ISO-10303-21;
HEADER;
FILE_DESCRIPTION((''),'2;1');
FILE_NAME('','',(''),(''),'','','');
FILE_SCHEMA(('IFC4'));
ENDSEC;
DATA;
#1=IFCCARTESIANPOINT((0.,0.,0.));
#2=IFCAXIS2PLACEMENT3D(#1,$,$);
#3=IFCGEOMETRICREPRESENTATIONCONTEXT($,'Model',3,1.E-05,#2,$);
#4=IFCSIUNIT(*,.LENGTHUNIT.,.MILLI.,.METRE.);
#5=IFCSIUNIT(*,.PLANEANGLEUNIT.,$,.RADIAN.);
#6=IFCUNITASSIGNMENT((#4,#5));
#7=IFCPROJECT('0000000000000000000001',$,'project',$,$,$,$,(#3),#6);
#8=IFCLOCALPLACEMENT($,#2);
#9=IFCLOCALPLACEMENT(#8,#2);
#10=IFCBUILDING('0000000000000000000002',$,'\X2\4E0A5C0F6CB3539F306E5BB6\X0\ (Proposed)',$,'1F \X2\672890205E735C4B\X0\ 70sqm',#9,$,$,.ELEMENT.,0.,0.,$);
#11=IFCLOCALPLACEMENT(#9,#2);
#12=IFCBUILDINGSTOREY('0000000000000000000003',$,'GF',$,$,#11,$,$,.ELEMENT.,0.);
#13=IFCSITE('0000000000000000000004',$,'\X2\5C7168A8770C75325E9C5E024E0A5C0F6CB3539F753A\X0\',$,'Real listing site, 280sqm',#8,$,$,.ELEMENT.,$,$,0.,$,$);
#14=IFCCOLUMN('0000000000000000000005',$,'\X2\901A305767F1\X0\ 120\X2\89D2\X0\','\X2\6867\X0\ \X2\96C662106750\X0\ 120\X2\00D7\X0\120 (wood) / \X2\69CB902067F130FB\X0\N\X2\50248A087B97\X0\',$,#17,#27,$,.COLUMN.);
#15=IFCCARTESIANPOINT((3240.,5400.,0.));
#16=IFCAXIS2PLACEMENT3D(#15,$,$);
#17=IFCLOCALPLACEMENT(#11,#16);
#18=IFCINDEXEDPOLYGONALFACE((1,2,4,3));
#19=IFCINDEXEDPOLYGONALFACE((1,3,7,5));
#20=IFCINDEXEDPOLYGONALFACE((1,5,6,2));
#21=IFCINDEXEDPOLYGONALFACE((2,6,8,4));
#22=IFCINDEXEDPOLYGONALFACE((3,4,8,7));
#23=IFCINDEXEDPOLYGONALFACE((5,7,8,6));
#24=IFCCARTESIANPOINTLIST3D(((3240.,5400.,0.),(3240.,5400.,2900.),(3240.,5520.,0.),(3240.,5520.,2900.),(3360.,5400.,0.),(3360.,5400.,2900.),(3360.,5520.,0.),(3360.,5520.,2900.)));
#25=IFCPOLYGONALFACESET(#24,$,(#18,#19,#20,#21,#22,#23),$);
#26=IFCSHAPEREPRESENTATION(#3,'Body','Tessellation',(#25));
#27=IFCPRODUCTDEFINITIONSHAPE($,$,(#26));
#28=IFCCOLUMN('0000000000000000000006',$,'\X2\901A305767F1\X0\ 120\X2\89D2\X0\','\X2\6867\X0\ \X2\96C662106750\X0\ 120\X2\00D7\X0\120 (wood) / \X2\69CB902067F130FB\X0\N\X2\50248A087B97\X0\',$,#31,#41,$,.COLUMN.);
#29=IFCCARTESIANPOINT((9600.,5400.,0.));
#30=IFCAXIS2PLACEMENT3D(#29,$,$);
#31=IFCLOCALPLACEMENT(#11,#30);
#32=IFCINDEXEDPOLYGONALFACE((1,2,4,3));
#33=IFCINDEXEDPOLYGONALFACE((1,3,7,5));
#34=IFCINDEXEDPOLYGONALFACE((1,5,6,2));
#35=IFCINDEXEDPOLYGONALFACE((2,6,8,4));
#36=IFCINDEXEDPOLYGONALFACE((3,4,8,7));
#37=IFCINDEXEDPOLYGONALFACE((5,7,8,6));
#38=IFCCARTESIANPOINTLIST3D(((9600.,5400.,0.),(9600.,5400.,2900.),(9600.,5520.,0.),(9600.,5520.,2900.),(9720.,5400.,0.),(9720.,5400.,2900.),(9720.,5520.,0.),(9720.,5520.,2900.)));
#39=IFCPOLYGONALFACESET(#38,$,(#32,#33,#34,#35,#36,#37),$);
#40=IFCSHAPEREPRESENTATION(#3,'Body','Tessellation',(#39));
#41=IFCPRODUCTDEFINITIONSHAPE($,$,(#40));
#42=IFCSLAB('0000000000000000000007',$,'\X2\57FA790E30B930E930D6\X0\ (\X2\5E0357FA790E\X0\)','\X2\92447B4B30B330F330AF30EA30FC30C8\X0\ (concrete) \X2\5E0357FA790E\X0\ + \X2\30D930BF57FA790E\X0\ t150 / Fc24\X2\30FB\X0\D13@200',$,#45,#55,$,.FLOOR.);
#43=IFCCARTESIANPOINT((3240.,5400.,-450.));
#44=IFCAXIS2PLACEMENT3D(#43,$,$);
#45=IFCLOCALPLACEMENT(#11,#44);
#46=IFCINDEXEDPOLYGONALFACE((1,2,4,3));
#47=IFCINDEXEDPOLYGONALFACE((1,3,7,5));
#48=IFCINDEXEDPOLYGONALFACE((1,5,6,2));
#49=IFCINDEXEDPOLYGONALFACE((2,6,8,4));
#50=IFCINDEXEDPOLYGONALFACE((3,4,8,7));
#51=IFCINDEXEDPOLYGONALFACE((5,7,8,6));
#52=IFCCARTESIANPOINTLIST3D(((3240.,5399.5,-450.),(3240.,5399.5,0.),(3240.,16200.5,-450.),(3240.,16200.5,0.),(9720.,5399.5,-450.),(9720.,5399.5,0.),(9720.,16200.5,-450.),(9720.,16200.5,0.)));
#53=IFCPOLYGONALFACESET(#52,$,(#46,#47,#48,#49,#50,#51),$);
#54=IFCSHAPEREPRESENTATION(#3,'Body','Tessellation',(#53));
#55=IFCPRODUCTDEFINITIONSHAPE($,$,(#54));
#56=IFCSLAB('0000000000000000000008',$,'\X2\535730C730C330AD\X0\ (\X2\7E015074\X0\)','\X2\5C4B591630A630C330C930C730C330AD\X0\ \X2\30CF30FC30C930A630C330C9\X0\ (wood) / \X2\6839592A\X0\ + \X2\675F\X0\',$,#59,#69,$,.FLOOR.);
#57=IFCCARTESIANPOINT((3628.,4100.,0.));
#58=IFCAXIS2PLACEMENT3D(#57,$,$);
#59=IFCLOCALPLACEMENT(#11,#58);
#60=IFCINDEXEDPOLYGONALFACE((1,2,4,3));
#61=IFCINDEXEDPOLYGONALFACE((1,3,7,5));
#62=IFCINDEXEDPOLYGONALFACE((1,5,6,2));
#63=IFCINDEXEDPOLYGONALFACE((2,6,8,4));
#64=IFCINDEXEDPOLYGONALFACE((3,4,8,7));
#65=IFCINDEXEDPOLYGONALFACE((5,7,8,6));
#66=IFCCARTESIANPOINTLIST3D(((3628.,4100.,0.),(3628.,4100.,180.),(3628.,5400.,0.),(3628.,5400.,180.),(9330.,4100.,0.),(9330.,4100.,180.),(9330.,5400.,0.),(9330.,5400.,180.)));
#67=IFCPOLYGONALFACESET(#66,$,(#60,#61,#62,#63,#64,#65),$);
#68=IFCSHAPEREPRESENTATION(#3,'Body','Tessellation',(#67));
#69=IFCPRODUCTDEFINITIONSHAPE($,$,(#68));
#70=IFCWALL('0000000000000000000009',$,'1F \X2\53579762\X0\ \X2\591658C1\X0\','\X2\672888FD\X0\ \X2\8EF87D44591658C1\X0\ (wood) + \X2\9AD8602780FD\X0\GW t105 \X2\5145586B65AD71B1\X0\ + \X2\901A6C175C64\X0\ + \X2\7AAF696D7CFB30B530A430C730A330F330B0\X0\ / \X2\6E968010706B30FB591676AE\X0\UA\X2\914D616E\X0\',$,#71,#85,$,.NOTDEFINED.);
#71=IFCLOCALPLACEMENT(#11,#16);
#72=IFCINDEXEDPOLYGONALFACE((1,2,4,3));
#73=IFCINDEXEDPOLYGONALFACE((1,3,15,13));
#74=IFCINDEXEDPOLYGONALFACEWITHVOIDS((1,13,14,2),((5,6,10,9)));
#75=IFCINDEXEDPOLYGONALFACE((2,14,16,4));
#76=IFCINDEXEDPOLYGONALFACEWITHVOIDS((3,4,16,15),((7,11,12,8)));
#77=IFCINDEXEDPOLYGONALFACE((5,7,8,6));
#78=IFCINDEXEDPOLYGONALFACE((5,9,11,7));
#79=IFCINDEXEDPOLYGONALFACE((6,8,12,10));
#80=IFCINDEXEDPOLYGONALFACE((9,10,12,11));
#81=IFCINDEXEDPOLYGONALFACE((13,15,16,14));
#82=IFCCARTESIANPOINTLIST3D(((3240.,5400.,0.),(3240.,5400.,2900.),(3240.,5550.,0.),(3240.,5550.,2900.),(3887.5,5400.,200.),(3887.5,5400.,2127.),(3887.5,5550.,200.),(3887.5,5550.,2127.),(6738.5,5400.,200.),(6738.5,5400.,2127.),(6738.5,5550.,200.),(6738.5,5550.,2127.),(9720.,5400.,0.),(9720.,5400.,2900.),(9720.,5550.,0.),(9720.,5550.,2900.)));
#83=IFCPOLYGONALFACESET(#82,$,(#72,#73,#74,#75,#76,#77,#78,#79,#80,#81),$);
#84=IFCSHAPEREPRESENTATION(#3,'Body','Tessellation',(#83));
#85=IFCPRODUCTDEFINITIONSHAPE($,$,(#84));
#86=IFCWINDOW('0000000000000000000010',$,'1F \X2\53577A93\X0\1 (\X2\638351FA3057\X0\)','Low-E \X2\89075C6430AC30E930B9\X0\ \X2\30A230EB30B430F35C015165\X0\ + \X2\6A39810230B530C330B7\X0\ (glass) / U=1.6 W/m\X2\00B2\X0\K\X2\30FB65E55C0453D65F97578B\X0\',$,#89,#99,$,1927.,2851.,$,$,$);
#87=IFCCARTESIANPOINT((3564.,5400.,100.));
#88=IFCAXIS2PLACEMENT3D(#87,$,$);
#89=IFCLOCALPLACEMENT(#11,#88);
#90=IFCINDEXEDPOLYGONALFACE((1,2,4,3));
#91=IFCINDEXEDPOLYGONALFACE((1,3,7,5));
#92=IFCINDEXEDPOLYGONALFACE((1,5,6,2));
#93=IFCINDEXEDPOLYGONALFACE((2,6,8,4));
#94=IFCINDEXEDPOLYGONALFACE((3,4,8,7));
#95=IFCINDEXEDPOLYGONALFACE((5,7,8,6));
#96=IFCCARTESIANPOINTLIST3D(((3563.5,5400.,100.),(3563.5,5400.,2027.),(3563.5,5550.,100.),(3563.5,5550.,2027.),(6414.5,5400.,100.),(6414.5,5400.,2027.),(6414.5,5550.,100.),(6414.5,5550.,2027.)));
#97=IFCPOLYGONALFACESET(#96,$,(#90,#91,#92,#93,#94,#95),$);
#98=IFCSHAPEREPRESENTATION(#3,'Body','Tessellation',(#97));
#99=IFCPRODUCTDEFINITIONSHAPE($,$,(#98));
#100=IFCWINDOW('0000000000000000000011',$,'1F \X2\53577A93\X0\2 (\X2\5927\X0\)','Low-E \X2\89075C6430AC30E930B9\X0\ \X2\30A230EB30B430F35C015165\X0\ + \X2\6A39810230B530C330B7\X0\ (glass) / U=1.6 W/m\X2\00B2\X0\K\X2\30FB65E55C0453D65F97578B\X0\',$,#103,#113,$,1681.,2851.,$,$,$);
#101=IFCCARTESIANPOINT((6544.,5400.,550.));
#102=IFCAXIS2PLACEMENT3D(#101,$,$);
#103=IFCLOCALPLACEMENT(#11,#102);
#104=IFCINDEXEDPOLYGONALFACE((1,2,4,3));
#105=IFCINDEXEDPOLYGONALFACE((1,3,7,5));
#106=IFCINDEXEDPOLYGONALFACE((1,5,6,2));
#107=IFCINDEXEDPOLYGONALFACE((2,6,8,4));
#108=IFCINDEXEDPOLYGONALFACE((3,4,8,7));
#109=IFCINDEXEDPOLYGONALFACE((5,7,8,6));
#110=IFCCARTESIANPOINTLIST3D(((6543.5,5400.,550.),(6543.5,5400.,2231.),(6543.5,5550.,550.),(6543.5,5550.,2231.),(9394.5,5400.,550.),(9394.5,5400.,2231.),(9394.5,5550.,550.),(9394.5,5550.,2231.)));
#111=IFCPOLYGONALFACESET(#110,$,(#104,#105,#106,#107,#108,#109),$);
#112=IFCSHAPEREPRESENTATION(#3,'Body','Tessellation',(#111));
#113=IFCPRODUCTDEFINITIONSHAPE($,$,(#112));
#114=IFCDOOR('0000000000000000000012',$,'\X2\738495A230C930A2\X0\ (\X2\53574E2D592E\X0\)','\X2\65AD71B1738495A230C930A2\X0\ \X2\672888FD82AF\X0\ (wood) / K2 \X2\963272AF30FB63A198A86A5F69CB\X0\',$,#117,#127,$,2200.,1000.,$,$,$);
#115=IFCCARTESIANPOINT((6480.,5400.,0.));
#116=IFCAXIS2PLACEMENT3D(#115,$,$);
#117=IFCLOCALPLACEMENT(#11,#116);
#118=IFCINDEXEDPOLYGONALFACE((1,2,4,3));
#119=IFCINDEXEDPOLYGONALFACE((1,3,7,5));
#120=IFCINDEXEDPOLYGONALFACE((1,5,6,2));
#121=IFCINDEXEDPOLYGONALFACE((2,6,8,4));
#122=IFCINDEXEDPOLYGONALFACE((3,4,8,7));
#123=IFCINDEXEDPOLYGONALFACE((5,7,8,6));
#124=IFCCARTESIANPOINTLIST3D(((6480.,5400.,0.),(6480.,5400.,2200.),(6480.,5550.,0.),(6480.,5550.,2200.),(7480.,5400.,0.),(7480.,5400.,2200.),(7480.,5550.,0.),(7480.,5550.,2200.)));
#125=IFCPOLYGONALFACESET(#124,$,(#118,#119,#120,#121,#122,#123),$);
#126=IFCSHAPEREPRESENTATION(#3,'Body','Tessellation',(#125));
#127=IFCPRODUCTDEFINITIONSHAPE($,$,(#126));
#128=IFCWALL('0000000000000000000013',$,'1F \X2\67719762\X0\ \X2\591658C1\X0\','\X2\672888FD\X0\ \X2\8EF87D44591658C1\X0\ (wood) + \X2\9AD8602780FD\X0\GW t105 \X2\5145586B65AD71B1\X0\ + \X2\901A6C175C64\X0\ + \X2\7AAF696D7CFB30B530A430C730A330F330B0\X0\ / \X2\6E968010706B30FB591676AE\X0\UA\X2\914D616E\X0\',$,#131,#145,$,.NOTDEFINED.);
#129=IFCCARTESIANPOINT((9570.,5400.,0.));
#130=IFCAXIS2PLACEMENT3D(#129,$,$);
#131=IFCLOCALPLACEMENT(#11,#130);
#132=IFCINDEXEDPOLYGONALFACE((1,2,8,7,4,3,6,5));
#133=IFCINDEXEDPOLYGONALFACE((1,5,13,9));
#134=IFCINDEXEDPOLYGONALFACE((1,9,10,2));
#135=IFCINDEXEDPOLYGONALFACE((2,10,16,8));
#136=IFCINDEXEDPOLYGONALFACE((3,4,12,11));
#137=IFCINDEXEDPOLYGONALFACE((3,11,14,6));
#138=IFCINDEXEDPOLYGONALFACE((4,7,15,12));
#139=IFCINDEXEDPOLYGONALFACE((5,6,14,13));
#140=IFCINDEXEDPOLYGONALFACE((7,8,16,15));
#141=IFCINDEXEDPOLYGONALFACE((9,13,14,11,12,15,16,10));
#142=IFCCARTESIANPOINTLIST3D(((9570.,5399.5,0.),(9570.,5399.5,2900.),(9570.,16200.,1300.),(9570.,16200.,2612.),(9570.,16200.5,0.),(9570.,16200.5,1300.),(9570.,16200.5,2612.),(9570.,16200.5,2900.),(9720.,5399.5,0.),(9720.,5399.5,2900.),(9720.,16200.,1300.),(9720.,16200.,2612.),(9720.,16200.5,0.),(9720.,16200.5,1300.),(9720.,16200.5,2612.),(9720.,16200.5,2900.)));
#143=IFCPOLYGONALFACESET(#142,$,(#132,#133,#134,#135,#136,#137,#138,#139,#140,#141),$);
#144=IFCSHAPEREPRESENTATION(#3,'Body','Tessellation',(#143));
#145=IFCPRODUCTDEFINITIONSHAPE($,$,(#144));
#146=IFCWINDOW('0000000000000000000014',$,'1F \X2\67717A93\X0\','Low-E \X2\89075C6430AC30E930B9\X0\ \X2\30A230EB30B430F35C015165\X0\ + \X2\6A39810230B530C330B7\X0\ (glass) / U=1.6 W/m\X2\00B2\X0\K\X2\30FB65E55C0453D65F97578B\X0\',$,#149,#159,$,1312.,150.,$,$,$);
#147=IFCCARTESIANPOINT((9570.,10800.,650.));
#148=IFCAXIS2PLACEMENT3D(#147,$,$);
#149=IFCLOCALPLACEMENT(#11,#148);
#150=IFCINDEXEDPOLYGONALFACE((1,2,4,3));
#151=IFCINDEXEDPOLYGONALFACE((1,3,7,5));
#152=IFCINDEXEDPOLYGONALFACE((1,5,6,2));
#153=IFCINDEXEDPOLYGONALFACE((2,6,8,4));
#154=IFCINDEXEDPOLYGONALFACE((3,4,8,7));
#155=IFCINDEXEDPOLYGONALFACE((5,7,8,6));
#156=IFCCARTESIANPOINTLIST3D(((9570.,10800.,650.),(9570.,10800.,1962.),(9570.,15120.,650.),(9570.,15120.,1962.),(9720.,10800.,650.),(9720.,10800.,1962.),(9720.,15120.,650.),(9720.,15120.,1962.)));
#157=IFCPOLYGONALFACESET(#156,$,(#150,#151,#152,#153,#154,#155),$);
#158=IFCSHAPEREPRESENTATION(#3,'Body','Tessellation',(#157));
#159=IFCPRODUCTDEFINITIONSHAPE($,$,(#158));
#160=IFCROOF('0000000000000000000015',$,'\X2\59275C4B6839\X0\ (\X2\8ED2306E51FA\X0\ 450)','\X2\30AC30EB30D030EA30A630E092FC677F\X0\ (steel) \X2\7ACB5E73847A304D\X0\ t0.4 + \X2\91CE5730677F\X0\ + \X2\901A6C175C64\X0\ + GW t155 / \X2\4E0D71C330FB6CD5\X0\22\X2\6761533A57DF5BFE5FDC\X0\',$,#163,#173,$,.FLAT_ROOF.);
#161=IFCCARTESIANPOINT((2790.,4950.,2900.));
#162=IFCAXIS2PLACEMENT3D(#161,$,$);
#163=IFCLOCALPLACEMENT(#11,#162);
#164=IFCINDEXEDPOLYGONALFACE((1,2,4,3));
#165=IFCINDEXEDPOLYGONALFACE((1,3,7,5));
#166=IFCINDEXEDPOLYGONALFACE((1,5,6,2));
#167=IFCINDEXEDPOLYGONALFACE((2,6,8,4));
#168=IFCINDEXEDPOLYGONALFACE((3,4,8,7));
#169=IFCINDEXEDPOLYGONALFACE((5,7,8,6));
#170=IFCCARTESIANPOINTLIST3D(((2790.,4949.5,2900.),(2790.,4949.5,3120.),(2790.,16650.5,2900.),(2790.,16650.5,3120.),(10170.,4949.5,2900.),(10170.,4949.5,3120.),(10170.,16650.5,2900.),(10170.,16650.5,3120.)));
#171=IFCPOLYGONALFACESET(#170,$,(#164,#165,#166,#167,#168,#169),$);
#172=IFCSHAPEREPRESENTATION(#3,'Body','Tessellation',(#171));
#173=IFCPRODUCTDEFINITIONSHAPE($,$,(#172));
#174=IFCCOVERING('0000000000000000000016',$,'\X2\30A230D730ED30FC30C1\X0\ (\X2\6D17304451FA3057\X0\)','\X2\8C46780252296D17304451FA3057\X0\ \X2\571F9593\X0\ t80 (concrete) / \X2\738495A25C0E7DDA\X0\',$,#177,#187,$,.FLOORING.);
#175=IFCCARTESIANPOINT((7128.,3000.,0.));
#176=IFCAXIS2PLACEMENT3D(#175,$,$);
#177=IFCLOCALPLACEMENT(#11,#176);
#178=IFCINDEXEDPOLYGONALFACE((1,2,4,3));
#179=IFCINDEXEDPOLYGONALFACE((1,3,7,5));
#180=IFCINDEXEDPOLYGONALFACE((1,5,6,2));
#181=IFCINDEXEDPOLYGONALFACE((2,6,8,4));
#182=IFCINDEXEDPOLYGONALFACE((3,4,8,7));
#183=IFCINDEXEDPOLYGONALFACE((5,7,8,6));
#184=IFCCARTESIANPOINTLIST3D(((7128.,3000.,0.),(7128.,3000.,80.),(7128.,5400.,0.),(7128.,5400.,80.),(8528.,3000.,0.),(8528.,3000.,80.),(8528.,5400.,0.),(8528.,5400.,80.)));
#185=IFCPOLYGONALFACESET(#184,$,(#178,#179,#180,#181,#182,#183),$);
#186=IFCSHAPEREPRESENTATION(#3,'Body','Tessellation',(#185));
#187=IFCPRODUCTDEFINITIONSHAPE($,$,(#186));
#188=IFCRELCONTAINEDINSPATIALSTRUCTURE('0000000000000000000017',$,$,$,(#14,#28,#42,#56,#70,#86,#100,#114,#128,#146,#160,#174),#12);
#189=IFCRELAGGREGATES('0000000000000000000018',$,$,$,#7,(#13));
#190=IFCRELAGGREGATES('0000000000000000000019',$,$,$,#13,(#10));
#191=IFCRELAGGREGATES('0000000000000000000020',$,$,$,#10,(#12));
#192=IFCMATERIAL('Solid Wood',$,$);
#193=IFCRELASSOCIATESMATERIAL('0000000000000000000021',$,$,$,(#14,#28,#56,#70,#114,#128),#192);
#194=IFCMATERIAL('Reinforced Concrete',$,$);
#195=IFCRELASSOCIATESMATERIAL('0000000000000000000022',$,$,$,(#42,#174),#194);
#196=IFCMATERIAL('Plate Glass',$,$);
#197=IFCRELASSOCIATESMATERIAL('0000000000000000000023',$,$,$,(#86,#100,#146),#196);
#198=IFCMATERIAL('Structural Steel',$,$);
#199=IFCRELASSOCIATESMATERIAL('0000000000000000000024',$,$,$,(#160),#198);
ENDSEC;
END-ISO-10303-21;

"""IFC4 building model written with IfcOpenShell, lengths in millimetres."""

from ifc_helpers import new_model, si_unit, frame, frame_2d, origin, place, context, project, spatial, rectangle, extrude, material, element, fill, save


model = new_model("IFC4")

# Units and contexts
model_context = context("Model", 3, precision=1e-05, world=origin())
ifc_project = project(units=[si_unit("LENGTHUNIT", "METRE", prefix="MILLI"), si_unit("PLANEANGLEUNIT", "RADIAN")], contexts=[model_context])

# Site, building, storey
site_placement = place(None, origin())
site = spatial("IfcSite", under=ifc_project, at=site_placement, Name="山梨県甲府市上小河原町", ObjectType="Real listing site, 280sqm", CompositionType="ELEMENT", RefElevation=0.0)
building_placement = place(site_placement, origin())
building = spatial("IfcBuilding", under=site, at=building_placement, Name="上小河原の家 (Proposed)", ObjectType="1F 木造平屋 70sqm", CompositionType="ELEMENT", ElevationOfRefHeight=0.0, ElevationOfTerrain=0.0)
storey_placement = place(building_placement, origin())
storey = spatial("IfcBuildingStorey", under=building, at=storey_placement, Name="GF", CompositionType="ELEMENT", Elevation=0.0)

# Columns
ifc_material_1 = material(Name="Solid Wood")
column_1_placement = place(storey_placement, frame((3240.0, 5400.0, 0.0)))
element("IfcColumn", 1, at=column_1_placement, inside=storey, material=ifc_material_1, Name="通し柱 120角", Description="桧 集成材 120×120 (wood) / 構造柱・N値計算", PredefinedType="COLUMN", context=model_context, shape_type="SweptSolid", body=[
    extrude(rectangle(XDim=120.0, YDim=120.0, at=frame_2d((60.0, 60.0))), frame((3240.0, 5400.0, 0.0)), (0.0, 0.0, 1.0), 2900.0),
])
column_2_placement = place(storey_placement, frame((9600.0, 5400.0, 0.0)))
element("IfcColumn", 2, at=column_2_placement, inside=storey, material=ifc_material_1, Name="通し柱 120角", Description="桧 集成材 120×120 (wood) / 構造柱・N値計算", PredefinedType="COLUMN", context=model_context, shape_type="SweptSolid", body=[
    extrude(rectangle(XDim=120.0, YDim=120.0, at=frame_2d((60.0, 60.0))), frame((9600.0, 5400.0, 0.0)), (0.0, 0.0, 1.0), 2900.0),
])

# Slabs
ifc_material_2 = material(Name="Reinforced Concrete")
slab_1_placement = place(storey_placement, frame((3240.0, 5400.0, -450.0)))
element("IfcSlab", 3, at=slab_1_placement, inside=storey, material=ifc_material_2, Name="基礎スラブ (布基礎)", Description="鉄筋コンクリート (concrete) 布基礎 + ベタ基礎 t150 / Fc24・D13@200", PredefinedType="FLOOR", context=model_context, shape_type="SweptSolid", body=[
    extrude(rectangle(XDim=6480.0, YDim=10801.0, at=frame_2d((3240.0, 5400.0))), frame((3240.0, 5400.0, -450.0)), (0.0, 0.0, 1.0), 450.0),
])
slab_2_placement = place(storey_placement, frame((3628.0, 4100.0, 0.0)))
element("IfcSlab", 4, at=slab_2_placement, inside=storey, material=ifc_material_1, Name="南デッキ (縁側)", Description="屋外ウッドデッキ ハードウッド (wood) / 根太 + 束", PredefinedType="FLOOR", context=model_context, shape_type="SweptSolid", body=[
    extrude(rectangle(XDim=5702.0, YDim=1300.0, at=frame_2d((2851.0, 650.0))), frame((3628.0, 4100.0, 0.0)), (0.0, 0.0, 1.0), 180.0),
])

# Wall, openings, windows, door
wall_1_placement = place(storey_placement, frame((3240.0, 5400.0, 0.0)))
wall_1 = element("IfcWall", 5, at=wall_1_placement, inside=storey, material=ifc_material_1, Name="1F 南面 外壁", Description="木製 軸組外壁 (wood) + 高性能GW t105 充填断熱 + 通気層 + 窯業系サイディング / 準耐火・外皮UA配慮", PredefinedType="NOTDEFINED", context=model_context, shape_type="SweptSolid", body=[
    extrude(rectangle(XDim=6480.0, YDim=150.0, at=frame_2d((3240.0, 75.0))), frame((3240.0, 5400.0, 0.0)), (0.0, 0.0, 1.0), 2900.0),
])
opening_1_placement = place(storey_placement, frame((3564.0, 5400.0, 100.0)))
opening_1 = element("IfcOpeningElement", 6, at=opening_1_placement, cuts=wall_1, PredefinedType="NOTDEFINED", context=model_context, shape_type="SweptSolid", body=[
    extrude(rectangle(XDim=2851.0, YDim=150.0, at=frame_2d((1425.0, 75.0))), frame((3564.0, 5400.0, 100.0)), (0.0, 0.0, 1.0), 1927.0),
])
opening_2_placement = place(storey_placement, frame((6544.0, 5400.0, 550.0)))
opening_2 = element("IfcOpeningElement", 7, at=opening_2_placement, cuts=wall_1, PredefinedType="NOTDEFINED", context=model_context, shape_type="SweptSolid", body=[
    extrude(rectangle(XDim=2851.0, YDim=150.0, at=frame_2d((1425.0, 75.0))), frame((6544.0, 5400.0, 550.0)), (0.0, 0.0, 1.0), 1681.0),
])
opening_3_placement = place(storey_placement, frame((6480.0, 5400.0, 0.0)))
opening_3 = element("IfcOpeningElement", 8, at=opening_3_placement, cuts=wall_1, PredefinedType="NOTDEFINED", context=model_context, shape_type="SweptSolid", body=[
    extrude(rectangle(XDim=1000.0, YDim=150.0, at=frame_2d((500.0, 75.0))), frame((6480.0, 5400.0, 0.0)), (0.0, 0.0, 1.0), 2200.0),
])
ifc_material_3 = material(Name="Plate Glass")
window_1_placement = place(storey_placement, frame((3564.0, 5400.0, 100.0)))
window_1 = element("IfcWindow", 9, at=window_1_placement, inside=storey, material=ifc_material_3, Name="1F 南窓1 (掃出し)", Description="Low-E 複層ガラス アルゴン封入 + 樹脂サッシ (glass) / U=1.6 W/m²K・日射取得型", OverallHeight=1927.0, OverallWidth=2851.0, context=model_context, shape_type="SweptSolid", body=[
    extrude(rectangle(XDim=2851.0, YDim=150.0, at=frame_2d((1425.0, 75.0))), frame((3564.0, 5400.0, 100.0)), (0.0, 0.0, 1.0), 1927.0),
])
fill(opening_1, window_1)
window_2_placement = place(storey_placement, frame((6544.0, 5400.0, 550.0)))
window_2 = element("IfcWindow", 10, at=window_2_placement, inside=storey, material=ifc_material_3, Name="1F 南窓2 (大)", Description="Low-E 複層ガラス アルゴン封入 + 樹脂サッシ (glass) / U=1.6 W/m²K・日射取得型", OverallHeight=1681.0, OverallWidth=2851.0, context=model_context, shape_type="SweptSolid", body=[
    extrude(rectangle(XDim=2851.0, YDim=150.0, at=frame_2d((1425.0, 75.0))), frame((6544.0, 5400.0, 550.0)), (0.0, 0.0, 1.0), 1681.0),
])
fill(opening_2, window_2)
door_placement = place(storey_placement, frame((6480.0, 5400.0, 0.0)))
door = element("IfcDoor", 11, at=door_placement, inside=storey, material=ifc_material_1, Name="玄関ドア (南中央)", Description="断熱玄関ドア 木製芯 (wood) / K2 防犯・採風機構", OverallHeight=2200.0, OverallWidth=1000.0, context=model_context, shape_type="SweptSolid", body=[
    extrude(rectangle(XDim=1000.0, YDim=150.0, at=frame_2d((500.0, 75.0))), frame((6480.0, 5400.0, 0.0)), (0.0, 0.0, 1.0), 2200.0),
])
fill(opening_3, door)

# Wall, opening, window
wall_2_placement = place(storey_placement, frame((9570.0, 5400.0, 0.0)))
wall_2 = element("IfcWall", 12, at=wall_2_placement, inside=storey, material=ifc_material_1, Name="1F 東面 外壁", Description="木製 軸組外壁 (wood) + 高性能GW t105 充填断熱 + 通気層 + 窯業系サイディング / 準耐火・外皮UA配慮", PredefinedType="NOTDEFINED", context=model_context, shape_type="SweptSolid", body=[
    extrude(rectangle(XDim=150.0, YDim=10801.0, at=frame_2d((75.0, 5400.0))), frame((9570.0, 5400.0, 0.0)), (0.0, 0.0, 1.0), 2900.0),
])
opening_4_placement = place(storey_placement, frame((9570.0, 10800.0, 650.0)))
opening_4 = element("IfcOpeningElement", 13, at=opening_4_placement, cuts=wall_2, PredefinedType="NOTDEFINED", context=model_context, shape_type="SweptSolid", body=[
    extrude(rectangle(XDim=150.0, YDim=4320.0, at=frame_2d((75.0, 2160.0))), frame((9570.0, 10800.0, 650.0)), (0.0, 0.0, 1.0), 1312.0),
])
window_3_placement = place(storey_placement, frame((9570.0, 10800.0, 650.0)))
window_3 = element("IfcWindow", 14, at=window_3_placement, inside=storey, material=ifc_material_3, Name="1F 東窓", Description="Low-E 複層ガラス アルゴン封入 + 樹脂サッシ (glass) / U=1.6 W/m²K・日射取得型", OverallHeight=1312.0, OverallWidth=150.0, context=model_context, shape_type="SweptSolid", body=[
    extrude(rectangle(XDim=150.0, YDim=4320.0, at=frame_2d((75.0, 2160.0))), frame((9570.0, 10800.0, 650.0)), (0.0, 0.0, 1.0), 1312.0),
])
fill(opening_4, window_3)

# Roof
ifc_material_4 = material(Name="Structural Steel")
roof_placement = place(storey_placement, frame((2790.0, 4950.0, 2900.0)))
element("IfcRoof", 15, at=roof_placement, inside=storey, material=ifc_material_4, Name="大屋根 (軒の出 450)", Description="ガルバリウム鋼板 (steel) 立平葺き t0.4 + 野地板 + 通気層 + GW t155 / 不燃・法22条区域対応", PredefinedType="FLAT_ROOF", context=model_context, shape_type="SweptSolid", body=[
    extrude(rectangle(XDim=7380.0, YDim=11701.0, at=frame_2d((3690.0, 5850.0))), frame((2790.0, 4950.0, 2900.0)), (0.0, 0.0, 1.0), 220.0),
])

# Covering
covering_1_placement = place(storey_placement, frame((7128.0, 3000.0, 0.0)))
element("IfcCovering", 16, at=covering_1_placement, inside=storey, material=ifc_material_2, Name="アプローチ (洗い出し)", Description="豆砂利洗い出し 土間 t80 (concrete) / 玄関導線", PredefinedType="FLOORING", context=model_context, shape_type="SweptSolid", body=[
    extrude(rectangle(XDim=1400.0, YDim=2400.0, at=frame_2d((700.0, 1200.0))), frame((7128.0, 3000.0, 0.0)), (0.0, 0.0, 1.0), 80.0),
])

save(model, "model.ifc")
